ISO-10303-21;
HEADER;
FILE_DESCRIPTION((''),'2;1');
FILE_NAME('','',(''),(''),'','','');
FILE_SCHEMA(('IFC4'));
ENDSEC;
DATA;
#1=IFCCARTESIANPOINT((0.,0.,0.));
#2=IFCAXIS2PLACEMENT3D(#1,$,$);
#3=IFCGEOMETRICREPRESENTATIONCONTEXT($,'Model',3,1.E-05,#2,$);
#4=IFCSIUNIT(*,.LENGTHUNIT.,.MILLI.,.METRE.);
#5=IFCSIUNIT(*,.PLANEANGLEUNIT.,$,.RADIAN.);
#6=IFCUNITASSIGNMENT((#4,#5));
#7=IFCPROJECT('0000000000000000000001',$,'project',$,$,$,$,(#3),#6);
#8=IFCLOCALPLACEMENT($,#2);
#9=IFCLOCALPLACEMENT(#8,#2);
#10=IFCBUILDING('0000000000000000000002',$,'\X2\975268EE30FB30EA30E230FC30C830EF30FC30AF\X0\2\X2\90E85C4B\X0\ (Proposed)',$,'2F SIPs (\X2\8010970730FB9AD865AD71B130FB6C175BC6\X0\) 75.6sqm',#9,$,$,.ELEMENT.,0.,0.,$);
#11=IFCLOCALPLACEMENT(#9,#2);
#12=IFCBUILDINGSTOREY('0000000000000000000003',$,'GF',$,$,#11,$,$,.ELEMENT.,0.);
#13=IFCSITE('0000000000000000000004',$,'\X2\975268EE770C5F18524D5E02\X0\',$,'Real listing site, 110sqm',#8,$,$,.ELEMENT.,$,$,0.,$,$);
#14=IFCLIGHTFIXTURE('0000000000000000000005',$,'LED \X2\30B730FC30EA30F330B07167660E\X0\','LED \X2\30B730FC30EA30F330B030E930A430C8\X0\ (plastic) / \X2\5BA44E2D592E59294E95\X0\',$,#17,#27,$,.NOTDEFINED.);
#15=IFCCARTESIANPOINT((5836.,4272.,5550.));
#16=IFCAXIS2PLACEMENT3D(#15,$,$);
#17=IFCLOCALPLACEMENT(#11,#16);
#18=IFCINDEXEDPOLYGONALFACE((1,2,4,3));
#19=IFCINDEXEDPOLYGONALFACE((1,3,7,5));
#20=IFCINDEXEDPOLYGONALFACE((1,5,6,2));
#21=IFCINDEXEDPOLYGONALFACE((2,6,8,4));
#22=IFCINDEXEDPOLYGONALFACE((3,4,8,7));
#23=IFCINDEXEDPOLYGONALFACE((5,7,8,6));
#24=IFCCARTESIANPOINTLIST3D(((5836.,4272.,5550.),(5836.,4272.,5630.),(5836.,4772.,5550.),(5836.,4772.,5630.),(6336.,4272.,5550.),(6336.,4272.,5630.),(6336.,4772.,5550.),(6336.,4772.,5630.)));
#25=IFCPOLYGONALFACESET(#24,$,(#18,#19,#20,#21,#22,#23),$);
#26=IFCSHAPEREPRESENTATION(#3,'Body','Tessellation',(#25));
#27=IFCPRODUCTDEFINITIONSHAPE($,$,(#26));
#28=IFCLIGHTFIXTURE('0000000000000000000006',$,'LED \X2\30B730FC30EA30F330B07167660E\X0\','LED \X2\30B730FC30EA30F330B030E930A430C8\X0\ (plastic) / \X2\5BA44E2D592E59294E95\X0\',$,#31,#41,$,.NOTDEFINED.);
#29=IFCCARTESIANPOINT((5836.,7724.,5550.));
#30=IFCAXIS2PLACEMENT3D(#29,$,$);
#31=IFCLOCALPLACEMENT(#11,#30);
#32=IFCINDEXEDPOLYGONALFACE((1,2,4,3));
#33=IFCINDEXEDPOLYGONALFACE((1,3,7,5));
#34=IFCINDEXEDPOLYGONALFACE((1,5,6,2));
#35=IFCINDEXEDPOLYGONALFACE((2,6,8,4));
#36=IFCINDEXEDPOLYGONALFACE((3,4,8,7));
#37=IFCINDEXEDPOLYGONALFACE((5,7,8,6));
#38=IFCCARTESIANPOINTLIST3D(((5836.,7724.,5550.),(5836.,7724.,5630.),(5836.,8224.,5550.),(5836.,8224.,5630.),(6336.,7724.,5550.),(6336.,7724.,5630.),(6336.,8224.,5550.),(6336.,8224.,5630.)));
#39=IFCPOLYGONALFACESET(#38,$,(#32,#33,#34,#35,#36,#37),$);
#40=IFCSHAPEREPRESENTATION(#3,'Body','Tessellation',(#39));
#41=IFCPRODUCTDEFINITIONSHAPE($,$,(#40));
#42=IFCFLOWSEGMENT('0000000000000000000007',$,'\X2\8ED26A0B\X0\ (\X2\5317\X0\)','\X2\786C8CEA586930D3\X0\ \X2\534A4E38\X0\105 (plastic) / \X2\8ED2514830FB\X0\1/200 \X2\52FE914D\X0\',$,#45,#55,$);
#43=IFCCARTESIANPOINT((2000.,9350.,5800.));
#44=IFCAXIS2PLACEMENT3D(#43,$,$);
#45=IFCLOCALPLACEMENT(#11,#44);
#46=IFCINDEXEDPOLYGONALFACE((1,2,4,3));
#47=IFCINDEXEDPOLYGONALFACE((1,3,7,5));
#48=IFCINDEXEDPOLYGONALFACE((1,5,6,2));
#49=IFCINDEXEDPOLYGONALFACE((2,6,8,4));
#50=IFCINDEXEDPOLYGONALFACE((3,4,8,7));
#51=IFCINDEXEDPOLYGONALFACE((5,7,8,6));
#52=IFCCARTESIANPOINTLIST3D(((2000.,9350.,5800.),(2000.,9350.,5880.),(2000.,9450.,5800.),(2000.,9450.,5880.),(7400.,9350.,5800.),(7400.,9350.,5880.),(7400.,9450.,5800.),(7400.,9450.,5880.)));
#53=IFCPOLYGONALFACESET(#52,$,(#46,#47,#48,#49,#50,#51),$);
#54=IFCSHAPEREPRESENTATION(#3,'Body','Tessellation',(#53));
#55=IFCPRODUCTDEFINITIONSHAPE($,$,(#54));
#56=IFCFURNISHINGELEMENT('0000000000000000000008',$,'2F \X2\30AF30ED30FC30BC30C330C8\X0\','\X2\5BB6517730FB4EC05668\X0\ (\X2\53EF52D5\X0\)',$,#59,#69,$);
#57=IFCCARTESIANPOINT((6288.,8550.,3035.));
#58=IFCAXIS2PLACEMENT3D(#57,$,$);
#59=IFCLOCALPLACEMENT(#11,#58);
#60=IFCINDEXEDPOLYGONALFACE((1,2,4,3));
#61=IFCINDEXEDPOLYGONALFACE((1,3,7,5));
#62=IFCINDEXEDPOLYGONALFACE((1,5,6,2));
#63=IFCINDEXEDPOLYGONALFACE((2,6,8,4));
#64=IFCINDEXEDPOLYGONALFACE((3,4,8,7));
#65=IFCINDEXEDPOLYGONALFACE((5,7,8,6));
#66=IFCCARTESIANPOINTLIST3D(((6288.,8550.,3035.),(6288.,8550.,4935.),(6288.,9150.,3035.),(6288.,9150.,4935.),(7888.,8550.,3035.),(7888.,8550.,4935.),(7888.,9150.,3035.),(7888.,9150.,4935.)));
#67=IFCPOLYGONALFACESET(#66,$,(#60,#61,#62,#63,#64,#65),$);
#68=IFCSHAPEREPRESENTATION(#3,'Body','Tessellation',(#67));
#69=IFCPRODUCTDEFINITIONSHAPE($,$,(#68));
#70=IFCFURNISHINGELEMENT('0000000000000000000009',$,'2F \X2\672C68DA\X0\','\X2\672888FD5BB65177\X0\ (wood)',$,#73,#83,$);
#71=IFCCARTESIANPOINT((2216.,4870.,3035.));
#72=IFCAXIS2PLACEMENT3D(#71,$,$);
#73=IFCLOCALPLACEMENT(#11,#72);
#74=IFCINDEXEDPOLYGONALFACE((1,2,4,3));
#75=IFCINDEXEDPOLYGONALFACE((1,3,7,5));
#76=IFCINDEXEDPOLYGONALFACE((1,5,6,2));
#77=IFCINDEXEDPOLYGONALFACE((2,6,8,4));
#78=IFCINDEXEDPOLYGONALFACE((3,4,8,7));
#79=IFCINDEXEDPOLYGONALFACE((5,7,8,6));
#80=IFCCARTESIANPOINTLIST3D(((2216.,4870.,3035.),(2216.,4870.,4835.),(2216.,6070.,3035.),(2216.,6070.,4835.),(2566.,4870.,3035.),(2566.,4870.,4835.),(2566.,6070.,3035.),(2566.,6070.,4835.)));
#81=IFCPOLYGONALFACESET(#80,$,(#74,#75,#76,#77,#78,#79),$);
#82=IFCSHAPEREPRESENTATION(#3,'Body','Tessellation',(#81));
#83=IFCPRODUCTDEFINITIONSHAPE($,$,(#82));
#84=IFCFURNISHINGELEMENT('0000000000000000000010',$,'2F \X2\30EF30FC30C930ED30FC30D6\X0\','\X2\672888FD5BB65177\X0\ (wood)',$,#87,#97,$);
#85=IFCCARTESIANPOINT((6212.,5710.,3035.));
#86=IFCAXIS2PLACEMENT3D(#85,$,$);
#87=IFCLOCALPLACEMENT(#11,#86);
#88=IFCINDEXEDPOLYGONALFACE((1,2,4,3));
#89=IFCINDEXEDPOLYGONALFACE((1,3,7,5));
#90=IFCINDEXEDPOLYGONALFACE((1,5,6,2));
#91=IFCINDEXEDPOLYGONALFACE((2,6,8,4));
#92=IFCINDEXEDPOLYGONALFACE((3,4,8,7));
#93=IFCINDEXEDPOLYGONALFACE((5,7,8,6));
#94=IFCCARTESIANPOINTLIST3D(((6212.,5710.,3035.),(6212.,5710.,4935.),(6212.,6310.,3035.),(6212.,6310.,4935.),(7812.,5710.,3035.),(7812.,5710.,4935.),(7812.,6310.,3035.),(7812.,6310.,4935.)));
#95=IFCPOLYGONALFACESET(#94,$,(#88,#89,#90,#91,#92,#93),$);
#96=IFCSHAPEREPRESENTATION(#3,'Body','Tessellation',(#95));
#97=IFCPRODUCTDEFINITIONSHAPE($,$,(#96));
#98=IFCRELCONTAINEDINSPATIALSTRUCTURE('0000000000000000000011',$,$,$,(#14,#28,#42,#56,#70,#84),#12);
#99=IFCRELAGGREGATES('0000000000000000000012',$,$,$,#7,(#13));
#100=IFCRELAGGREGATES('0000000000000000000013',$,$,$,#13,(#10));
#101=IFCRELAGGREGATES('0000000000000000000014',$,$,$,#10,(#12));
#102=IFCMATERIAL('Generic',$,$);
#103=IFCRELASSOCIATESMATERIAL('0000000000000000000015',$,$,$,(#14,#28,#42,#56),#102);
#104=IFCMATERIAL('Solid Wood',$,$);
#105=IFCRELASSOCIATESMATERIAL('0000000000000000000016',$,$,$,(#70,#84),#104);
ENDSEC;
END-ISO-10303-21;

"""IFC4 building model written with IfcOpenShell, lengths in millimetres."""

from ifc_helpers import new_model, si_unit, frame, frame_2d, origin, place, context, project, spatial, rectangle, extrude, material, element, save


model = new_model("IFC4")

# Units and contexts
model_context = context("Model", 3, precision=1e-05, world=origin())
ifc_project = project(units=[si_unit("LENGTHUNIT", "METRE", prefix="MILLI"), si_unit("PLANEANGLEUNIT", "RADIAN")], contexts=[model_context])

# Site, building, storey
site_placement = place(None, origin())
site = spatial("IfcSite", under=ifc_project, at=site_placement, Name="青森県弘前市", ObjectType="Real listing site, 110sqm", CompositionType="ELEMENT", RefElevation=0.0)
building_placement = place(site_placement, origin())
building = spatial("IfcBuilding", under=site, at=building_placement, Name="青森・リモートワーク2部屋 (Proposed)", ObjectType="2F SIPs (耐震・高断熱・気密) 75.6sqm", CompositionType="ELEMENT", ElevationOfRefHeight=0.0, ElevationOfTerrain=0.0)
storey_placement = place(building_placement, origin())
storey = spatial("IfcBuildingStorey", under=building, at=storey_placement, Name="GF", CompositionType="ELEMENT", Elevation=0.0)

# Shared definitions
ifc_material_1 = material(Name="Solid Wood")

# Light fixtures
ifc_material_2 = material(Name="Generic")
light_fixture_1_placement = place(storey_placement, frame((5836.0, 4272.0, 5550.0)))
element("IfcLightFixture", 1, at=light_fixture_1_placement, inside=storey, material=ifc_material_2, Name="LED シーリング照明", Description="LED シーリングライト (plastic) / 室中央天井", PredefinedType="NOTDEFINED", context=model_context, shape_type="SweptSolid", body=[
    extrude(rectangle(XDim=500.0, YDim=500.0, at=frame_2d((250.0, 250.0))), frame((5836.0, 4272.0, 5550.0)), (0.0, 0.0, 1.0), 80.0),
])
light_fixture_2_placement = place(storey_placement, frame((5836.0, 7724.0, 5550.0)))
element("IfcLightFixture", 2, at=light_fixture_2_placement, inside=storey, material=ifc_material_2, Name="LED シーリング照明", Description="LED シーリングライト (plastic) / 室中央天井", PredefinedType="NOTDEFINED", context=model_context, shape_type="SweptSolid", body=[
    extrude(rectangle(XDim=500.0, YDim=500.0, at=frame_2d((250.0, 250.0))), frame((5836.0, 7724.0, 5550.0)), (0.0, 0.0, 1.0), 80.0),
])

# Flow segment
flow_segment_placement = place(storey_placement, frame((2000.0, 9350.0, 5800.0)))
element("IfcFlowSegment", 3, at=flow_segment_placement, inside=storey, material=ifc_material_2, Name="軒樋 (北)", Description="硬質塩ビ 半丸105 (plastic) / 軒先・1/200 勾配", context=model_context, shape_type="SweptSolid", body=[
    extrude(rectangle(XDim=5400.0, YDim=100.0, at=frame_2d((2700.0, 50.0))), frame((2000.0, 9350.0, 5800.0)), (0.0, 0.0, 1.0), 80.0),
])

# Furnishing elements
furnishing_1_placement = place(storey_placement, frame((6288.0, 8550.0, 3035.0)))
element("IfcFurnishingElement", 4, at=furnishing_1_placement, inside=storey, material=ifc_material_2, Name="2F クローゼット", Description="家具・什器 (可動)", context=model_context, shape_type="SweptSolid", body=[
    extrude(rectangle(XDim=1600.0, YDim=600.0, at=frame_2d((800.0, 300.0))), frame((6288.0, 8550.0, 3035.0)), (0.0, 0.0, 1.0), 1900.0),
])
furnishing_2_placement = place(storey_placement, frame((2216.0, 4870.0, 3035.0)))
element("IfcFurnishingElement", 5, at=furnishing_2_placement, inside=storey, material=ifc_material_1, Name="2F 本棚", Description="木製家具 (wood)", context=model_context, shape_type="SweptSolid", body=[
    extrude(rectangle(XDim=350.0, YDim=1200.0, at=frame_2d((175.0, 600.0))), frame((2216.0, 4870.0, 3035.0)), (0.0, 0.0, 1.0), 1800.0),
])
furnishing_3_placement = place(storey_placement, frame((6212.0, 5710.0, 3035.0)))
element("IfcFurnishingElement", 6, at=furnishing_3_placement, inside=storey, material=ifc_material_1, Name="2F ワードローブ", Description="木製家具 (wood)", context=model_context, shape_type="SweptSolid", body=[
    extrude(rectangle(XDim=1600.0, YDim=600.0, at=frame_2d((800.0, 300.0))), frame((6212.0, 5710.0, 3035.0)), (0.0, 0.0, 1.0), 1900.0),
])

save(model, "model.ifc")
